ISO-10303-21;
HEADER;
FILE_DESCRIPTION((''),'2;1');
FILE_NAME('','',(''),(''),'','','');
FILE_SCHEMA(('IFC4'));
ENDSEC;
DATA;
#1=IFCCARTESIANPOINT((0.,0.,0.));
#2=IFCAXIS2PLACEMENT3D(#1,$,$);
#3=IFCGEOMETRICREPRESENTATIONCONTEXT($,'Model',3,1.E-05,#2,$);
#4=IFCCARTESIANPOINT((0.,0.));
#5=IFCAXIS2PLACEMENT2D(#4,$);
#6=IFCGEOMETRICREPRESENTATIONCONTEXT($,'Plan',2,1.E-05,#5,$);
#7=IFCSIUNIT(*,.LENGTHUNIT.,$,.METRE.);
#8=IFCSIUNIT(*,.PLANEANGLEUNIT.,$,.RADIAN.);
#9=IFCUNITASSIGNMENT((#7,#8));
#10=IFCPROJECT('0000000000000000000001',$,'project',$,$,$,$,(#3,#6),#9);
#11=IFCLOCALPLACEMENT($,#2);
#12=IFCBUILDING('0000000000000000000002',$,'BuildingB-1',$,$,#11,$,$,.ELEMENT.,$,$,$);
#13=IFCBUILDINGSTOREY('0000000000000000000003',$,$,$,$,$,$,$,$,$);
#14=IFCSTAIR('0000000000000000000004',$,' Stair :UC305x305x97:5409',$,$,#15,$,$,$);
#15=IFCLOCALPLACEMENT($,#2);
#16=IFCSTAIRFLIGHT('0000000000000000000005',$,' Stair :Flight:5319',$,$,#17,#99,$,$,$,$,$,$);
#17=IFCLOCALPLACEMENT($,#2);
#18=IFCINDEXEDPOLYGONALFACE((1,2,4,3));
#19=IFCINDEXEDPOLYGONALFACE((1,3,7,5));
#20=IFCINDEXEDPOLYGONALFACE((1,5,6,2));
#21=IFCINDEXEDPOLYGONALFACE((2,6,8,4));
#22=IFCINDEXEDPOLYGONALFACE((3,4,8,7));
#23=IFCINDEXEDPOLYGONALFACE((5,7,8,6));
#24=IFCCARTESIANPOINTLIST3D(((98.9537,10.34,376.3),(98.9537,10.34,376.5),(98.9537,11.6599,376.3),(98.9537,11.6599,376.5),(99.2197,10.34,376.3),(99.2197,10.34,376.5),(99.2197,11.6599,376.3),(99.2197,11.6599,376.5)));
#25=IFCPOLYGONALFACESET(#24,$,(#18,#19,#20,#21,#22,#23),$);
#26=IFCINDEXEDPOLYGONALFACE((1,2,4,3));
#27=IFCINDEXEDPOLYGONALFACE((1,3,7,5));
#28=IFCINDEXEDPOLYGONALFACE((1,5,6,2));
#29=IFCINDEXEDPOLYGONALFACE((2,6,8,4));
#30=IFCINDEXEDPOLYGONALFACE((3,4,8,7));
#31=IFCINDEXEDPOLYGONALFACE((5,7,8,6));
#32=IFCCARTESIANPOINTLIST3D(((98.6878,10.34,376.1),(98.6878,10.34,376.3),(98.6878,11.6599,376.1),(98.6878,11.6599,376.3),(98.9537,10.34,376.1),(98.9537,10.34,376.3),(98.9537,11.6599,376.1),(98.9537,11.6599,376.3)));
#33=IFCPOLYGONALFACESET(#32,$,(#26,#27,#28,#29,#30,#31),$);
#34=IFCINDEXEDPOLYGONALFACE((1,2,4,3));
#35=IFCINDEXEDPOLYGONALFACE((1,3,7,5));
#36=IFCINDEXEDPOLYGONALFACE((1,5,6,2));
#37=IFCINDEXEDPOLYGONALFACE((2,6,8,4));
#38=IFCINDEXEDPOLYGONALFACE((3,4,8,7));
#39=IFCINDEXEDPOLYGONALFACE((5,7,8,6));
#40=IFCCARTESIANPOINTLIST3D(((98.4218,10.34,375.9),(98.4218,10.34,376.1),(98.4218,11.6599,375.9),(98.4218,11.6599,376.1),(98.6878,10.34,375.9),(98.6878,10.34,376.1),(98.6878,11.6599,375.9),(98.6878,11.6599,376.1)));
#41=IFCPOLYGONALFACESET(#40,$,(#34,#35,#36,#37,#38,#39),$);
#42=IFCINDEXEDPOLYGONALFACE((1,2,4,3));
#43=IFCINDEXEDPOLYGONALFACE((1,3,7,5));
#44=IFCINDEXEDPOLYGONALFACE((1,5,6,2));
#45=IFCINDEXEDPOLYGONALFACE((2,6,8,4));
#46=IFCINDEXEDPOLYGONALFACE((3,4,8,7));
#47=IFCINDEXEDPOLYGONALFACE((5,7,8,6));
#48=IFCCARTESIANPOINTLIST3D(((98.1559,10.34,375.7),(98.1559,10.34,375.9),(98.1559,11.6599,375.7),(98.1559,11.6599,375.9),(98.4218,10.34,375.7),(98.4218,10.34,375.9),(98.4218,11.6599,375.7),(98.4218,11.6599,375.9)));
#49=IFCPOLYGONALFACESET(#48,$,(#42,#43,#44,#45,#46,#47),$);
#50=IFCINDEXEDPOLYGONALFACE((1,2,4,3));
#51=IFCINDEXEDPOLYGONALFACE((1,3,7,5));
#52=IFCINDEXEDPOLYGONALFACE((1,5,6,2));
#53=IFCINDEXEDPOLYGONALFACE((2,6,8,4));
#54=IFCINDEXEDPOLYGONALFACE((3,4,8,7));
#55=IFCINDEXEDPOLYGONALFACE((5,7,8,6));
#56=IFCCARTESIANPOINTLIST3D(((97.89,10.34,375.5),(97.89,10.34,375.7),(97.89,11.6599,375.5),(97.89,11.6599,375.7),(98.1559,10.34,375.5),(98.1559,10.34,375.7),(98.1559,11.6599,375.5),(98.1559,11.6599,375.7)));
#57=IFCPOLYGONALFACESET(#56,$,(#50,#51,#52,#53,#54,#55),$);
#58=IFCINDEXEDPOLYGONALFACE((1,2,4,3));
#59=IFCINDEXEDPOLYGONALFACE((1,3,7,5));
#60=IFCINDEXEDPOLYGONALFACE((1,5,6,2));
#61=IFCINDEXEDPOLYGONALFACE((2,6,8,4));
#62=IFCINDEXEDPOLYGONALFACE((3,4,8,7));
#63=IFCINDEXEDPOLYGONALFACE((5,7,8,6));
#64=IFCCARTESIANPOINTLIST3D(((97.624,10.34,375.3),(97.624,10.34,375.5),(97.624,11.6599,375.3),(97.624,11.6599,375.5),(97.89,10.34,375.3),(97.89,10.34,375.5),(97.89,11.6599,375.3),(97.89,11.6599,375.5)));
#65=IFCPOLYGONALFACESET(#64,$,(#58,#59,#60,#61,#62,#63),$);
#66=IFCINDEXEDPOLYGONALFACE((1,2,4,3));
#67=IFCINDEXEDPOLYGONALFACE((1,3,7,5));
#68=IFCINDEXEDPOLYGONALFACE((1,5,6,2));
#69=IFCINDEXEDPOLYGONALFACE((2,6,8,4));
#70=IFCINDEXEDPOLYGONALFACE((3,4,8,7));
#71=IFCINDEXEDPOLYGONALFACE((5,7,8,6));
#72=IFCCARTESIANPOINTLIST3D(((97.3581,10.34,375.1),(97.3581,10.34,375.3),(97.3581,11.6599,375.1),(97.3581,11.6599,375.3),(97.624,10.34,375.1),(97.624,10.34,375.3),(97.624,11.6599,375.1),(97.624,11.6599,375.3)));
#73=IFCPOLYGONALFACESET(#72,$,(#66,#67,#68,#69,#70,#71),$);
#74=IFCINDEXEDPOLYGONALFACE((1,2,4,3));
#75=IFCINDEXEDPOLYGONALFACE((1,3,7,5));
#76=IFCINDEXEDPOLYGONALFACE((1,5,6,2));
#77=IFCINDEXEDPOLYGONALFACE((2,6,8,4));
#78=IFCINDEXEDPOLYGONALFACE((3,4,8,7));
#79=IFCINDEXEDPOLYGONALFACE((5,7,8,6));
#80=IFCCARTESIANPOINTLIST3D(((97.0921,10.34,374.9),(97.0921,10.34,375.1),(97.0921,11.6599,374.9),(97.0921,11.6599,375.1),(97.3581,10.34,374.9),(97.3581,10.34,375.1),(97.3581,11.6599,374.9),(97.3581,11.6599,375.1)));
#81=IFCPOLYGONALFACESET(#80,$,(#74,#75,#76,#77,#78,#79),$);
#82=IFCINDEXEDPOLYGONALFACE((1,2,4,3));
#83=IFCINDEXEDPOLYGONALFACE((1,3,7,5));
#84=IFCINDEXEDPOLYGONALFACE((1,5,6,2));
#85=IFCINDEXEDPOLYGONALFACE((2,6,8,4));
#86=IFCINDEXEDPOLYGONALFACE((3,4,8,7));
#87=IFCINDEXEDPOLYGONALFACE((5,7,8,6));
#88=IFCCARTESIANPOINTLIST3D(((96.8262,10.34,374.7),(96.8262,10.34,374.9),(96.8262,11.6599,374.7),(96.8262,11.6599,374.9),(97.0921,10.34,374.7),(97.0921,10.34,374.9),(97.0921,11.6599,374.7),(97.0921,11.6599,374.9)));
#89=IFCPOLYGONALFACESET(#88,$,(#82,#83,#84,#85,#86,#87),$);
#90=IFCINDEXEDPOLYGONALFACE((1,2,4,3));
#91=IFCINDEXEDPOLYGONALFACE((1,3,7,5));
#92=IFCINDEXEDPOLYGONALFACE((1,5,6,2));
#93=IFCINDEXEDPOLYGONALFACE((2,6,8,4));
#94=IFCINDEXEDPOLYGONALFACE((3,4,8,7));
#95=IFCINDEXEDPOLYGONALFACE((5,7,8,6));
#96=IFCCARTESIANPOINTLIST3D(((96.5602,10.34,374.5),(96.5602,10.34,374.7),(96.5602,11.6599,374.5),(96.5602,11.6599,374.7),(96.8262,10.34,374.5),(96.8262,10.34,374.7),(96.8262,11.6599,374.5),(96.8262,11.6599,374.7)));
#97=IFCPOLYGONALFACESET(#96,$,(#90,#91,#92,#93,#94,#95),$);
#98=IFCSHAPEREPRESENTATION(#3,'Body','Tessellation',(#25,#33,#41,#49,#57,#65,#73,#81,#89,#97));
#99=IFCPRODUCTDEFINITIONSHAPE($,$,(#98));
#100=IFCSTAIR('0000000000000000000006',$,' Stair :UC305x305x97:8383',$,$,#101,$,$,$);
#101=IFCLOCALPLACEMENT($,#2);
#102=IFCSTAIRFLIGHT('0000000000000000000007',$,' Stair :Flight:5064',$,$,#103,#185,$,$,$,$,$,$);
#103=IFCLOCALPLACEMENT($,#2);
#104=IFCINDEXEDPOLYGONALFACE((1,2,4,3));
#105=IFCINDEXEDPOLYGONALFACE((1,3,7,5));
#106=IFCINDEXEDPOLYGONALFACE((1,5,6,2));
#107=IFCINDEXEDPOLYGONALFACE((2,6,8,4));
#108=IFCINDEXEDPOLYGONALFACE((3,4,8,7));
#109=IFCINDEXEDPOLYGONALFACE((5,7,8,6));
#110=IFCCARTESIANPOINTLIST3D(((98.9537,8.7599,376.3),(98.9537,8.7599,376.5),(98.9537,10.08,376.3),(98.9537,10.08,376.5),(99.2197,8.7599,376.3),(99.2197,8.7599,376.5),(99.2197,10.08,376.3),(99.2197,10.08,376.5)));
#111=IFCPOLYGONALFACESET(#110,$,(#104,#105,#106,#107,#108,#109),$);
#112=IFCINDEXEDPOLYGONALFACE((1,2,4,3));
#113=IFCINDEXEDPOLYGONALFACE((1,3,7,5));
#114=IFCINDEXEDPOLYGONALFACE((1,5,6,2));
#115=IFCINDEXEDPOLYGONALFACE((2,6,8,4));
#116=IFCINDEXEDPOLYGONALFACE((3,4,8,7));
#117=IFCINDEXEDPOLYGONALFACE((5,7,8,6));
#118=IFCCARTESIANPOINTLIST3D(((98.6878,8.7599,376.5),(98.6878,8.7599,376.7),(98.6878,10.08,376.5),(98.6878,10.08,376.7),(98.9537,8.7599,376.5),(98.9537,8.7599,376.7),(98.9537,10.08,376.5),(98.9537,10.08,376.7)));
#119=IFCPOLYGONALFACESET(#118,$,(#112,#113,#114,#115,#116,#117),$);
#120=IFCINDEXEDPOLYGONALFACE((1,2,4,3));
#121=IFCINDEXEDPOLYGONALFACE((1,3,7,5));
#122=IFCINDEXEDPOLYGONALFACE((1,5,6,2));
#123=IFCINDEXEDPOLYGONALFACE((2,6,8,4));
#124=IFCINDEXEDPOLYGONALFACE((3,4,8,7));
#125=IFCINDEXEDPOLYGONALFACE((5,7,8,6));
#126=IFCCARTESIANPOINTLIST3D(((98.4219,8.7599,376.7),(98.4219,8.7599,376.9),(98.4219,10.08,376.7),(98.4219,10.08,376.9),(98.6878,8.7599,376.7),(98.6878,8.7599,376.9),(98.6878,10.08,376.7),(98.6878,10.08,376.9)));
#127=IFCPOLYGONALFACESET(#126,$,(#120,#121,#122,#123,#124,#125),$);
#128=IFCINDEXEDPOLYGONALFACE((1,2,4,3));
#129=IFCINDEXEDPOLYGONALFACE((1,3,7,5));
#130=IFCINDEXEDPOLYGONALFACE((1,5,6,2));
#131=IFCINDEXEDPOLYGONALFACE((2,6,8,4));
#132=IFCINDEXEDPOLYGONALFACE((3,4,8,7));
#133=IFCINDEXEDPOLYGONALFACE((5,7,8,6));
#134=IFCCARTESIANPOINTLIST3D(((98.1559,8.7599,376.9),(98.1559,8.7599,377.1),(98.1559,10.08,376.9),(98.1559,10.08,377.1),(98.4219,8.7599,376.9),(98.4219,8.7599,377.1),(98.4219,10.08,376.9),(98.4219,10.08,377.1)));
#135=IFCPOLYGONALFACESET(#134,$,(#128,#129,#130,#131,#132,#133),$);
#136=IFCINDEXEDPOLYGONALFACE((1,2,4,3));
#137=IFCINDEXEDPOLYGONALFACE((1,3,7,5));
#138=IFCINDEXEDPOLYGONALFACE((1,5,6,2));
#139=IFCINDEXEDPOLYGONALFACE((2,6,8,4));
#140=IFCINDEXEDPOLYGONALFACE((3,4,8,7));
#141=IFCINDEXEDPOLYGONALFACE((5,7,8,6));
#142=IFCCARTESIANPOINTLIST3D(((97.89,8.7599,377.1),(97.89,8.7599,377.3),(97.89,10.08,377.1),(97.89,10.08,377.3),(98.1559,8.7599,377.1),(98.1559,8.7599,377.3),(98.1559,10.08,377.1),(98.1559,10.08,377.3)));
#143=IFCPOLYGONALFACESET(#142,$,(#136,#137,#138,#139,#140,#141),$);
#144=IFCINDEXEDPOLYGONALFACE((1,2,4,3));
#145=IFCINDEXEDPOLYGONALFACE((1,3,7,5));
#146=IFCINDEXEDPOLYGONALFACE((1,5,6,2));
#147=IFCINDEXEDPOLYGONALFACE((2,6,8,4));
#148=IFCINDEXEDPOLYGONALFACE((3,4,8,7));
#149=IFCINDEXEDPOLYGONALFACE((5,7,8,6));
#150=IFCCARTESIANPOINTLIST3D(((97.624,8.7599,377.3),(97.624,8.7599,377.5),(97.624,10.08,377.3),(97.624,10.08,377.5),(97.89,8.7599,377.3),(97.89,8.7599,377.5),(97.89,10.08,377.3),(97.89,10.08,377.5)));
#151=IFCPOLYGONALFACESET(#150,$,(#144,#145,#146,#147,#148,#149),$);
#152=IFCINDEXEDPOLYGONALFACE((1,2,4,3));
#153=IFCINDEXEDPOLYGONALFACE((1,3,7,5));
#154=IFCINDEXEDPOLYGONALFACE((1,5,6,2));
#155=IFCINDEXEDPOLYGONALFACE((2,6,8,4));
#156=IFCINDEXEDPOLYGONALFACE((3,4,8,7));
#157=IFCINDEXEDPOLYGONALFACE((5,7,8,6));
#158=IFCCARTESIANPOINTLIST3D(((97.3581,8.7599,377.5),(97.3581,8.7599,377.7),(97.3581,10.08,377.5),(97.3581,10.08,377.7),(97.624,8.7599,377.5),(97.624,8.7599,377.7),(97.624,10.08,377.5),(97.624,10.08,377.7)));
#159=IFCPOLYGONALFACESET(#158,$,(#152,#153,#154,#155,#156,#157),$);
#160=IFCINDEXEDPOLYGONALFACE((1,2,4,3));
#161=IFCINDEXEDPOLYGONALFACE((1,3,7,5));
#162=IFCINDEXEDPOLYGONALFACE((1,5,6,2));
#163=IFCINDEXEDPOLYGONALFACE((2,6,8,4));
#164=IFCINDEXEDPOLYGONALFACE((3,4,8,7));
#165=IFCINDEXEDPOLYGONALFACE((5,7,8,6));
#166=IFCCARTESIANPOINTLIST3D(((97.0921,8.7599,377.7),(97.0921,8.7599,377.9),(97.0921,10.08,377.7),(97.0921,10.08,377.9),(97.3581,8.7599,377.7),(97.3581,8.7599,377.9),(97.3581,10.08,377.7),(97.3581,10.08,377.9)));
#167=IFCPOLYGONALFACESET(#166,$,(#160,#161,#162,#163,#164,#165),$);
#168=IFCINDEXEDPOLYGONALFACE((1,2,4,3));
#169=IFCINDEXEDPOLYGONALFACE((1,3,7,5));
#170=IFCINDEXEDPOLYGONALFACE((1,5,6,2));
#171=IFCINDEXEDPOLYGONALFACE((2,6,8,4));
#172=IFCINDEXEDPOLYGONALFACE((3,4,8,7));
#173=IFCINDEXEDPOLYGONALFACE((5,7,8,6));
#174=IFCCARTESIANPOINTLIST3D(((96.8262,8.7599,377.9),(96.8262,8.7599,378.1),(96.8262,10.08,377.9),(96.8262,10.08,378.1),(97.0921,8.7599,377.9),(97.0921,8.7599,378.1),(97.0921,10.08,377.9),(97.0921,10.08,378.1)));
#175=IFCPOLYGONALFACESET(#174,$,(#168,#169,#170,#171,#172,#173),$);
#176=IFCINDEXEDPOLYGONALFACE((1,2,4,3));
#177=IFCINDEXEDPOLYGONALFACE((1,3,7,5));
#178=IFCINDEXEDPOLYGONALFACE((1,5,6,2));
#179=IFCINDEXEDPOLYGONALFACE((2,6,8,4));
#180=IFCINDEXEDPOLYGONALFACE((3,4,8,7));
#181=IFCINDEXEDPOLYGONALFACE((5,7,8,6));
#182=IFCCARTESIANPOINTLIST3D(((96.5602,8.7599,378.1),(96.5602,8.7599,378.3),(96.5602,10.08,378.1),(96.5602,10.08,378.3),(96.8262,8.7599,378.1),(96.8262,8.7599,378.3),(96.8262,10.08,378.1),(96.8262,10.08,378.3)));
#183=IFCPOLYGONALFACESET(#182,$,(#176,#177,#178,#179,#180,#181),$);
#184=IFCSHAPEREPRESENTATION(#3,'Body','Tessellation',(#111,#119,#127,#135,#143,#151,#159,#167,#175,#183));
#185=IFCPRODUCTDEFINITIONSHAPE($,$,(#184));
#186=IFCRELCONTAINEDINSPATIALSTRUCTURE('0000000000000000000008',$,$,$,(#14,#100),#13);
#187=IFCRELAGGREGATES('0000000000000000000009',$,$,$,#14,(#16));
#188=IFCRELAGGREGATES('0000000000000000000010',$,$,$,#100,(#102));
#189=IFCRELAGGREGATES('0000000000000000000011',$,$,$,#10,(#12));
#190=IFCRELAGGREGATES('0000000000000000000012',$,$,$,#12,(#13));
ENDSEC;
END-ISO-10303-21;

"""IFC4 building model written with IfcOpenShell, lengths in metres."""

from ifc_helpers import new_model, si_unit, frame, origin, origin_2d, place, context, project, spatial, polyline, outline, extrude, element, aggregate, save


model = new_model("IFC4")

# Units and contexts
model_context = context("Model", 3, precision=1e-05, world=origin())
plan_context = context("Plan", 2, precision=1e-05, world=origin_2d())
ifc_project = project(units=[si_unit("LENGTHUNIT", "METRE"), si_unit("PLANEANGLEUNIT", "RADIAN")], contexts=[model_context, plan_context])

# Building, storey
building_placement = place(None, origin())
building = spatial("IfcBuilding", under=ifc_project, at=building_placement, Name="BuildingB-1", CompositionType="ELEMENT")
storey = spatial("IfcBuildingStorey", under=building)

# Stairs, stair flights
stair_1 = element("IfcStair", 1, inside=storey, Name=" Stair :UC305x305x97:5409")
stair_flight_1 = element("IfcStairFlight", 2, Name=" Stair :Flight:5319", context=model_context, shape_type="SweptSolid", body=[
    extrude(outline(polyline([(98.9537, 11.6599, 376.5), (98.9537, 10.34, 376.5), (99.2197, 10.34, 376.5), (99.2197, 11.6599, 376.5), (98.9537, 11.6599, 376.5)])), origin(), (0.0, 0.0, -1.0), 0.2),
    extrude(outline(polyline([(98.6878, 11.6599, 376.5), (98.6878, 10.34, 376.5), (98.9537, 10.34, 376.5), (98.9537, 11.6599, 376.5), (98.6878, 11.6599, 376.5)])), frame((0.0, 0.0, -0.2)), (0.0, 0.0, -1.0), 0.2),
    extrude(outline(polyline([(98.4218, 11.6599, 376.5), (98.4218, 10.34, 376.5), (98.6878, 10.34, 376.5), (98.6878, 11.6599, 376.5), (98.4218, 11.6599, 376.5)])), frame((0.0, 0.0, -0.4)), (0.0, 0.0, -1.0), 0.2),
    extrude(outline(polyline([(98.1559, 11.6599, 376.5), (98.1559, 10.34, 376.5), (98.4218, 10.34, 376.5), (98.4218, 11.6599, 376.5), (98.1559, 11.6599, 376.5)])), frame((0.0, 0.0, -0.6)), (0.0, 0.0, -1.0), 0.2),
    extrude(outline(polyline([(97.89, 11.6599, 376.5), (97.89, 10.34, 376.5), (98.1559, 10.34, 376.5), (98.1559, 11.6599, 376.5), (97.89, 11.6599, 376.5)])), frame((0.0, 0.0, -0.8)), (0.0, 0.0, -1.0), 0.2),
    extrude(outline(polyline([(97.624, 11.6599, 376.5), (97.624, 10.34, 376.5), (97.89, 10.34, 376.5), (97.89, 11.6599, 376.5), (97.624, 11.6599, 376.5)])), frame((0.0, 0.0, -1.0)), (0.0, 0.0, -1.0), 0.2),
    extrude(outline(polyline([(97.3581, 11.6599, 376.5), (97.3581, 10.34, 376.5), (97.624, 10.34, 376.5), (97.624, 11.6599, 376.5), (97.3581, 11.6599, 376.5)])), frame((0.0, 0.0, -1.2)), (0.0, 0.0, -1.0), 0.2),
    extrude(outline(polyline([(97.0921, 11.6599, 376.5), (97.0921, 10.34, 376.5), (97.3581, 10.34, 376.5), (97.3581, 11.6599, 376.5), (97.0921, 11.6599, 376.5)])), frame((0.0, 0.0, -1.4)), (0.0, 0.0, -1.0), 0.2),
    extrude(outline(polyline([(96.8262, 11.6599, 376.5), (96.8262, 10.34, 376.5), (97.0921, 10.34, 376.5), (97.0921, 11.6599, 376.5), (96.8262, 11.6599, 376.5)])), frame((0.0, 0.0, -1.6)), (0.0, 0.0, -1.0), 0.2),
    extrude(outline(polyline([(96.5602, 11.6599, 376.5), (96.5602, 10.34, 376.5), (96.8262, 10.34, 376.5), (96.8262, 11.6599, 376.5), (96.5602, 11.6599, 376.5)])), frame((0.0, 0.0, -1.8)), (0.0, 0.0, -1.0), 0.2),
])
aggregate(stair_1, [stair_flight_1])
stair_2 = element("IfcStair", 3, inside=storey, Name=" Stair :UC305x305x97:8383")
stair_flight_2 = element("IfcStairFlight", 4, Name=" Stair :Flight:5064", context=model_context, shape_type="SweptSolid", body=[
    extrude(outline(polyline([(98.9537, 8.7599, 376.5), (98.9537, 10.08, 376.5), (99.2197, 10.08, 376.5), (99.2197, 8.7599, 376.5), (98.9537, 8.7599, 376.5)])), origin(), (0.0, 0.0, -1.0), 0.2),
    extrude(outline(polyline([(98.6878, 8.7599, 376.5), (98.6878, 10.08, 376.5), (98.9537, 10.08, 376.5), (98.9537, 8.7599, 376.5), (98.6878, 8.7599, 376.5)])), frame((0.0, 0.0, 0.2)), (0.0, 0.0, -1.0), 0.2),
    extrude(outline(polyline([(98.4219, 8.7599, 376.5), (98.4219, 10.08, 376.5), (98.6878, 10.08, 376.5), (98.6878, 8.7599, 376.5), (98.4219, 8.7599, 376.5)])), frame((0.0, 0.0, 0.4)), (0.0, 0.0, -1.0), 0.2),
    extrude(outline(polyline([(98.1559, 8.7599, 376.5), (98.1559, 10.08, 376.5), (98.4219, 10.08, 376.5), (98.4219, 8.7599, 376.5), (98.1559, 8.7599, 376.5)])), frame((0.0, 0.0, 0.6)), (0.0, 0.0, -1.0), 0.2),
    extrude(outline(polyline([(97.89, 8.7599, 376.5), (97.89, 10.08, 376.5), (98.1559, 10.08, 376.5), (98.1559, 8.7599, 376.5), (97.89, 8.7599, 376.5)])), frame((0.0, 0.0, 0.8)), (0.0, 0.0, -1.0), 0.2),
    extrude(outline(polyline([(97.624, 8.7599, 376.5), (97.624, 10.08, 376.5), (97.89, 10.08, 376.5), (97.89, 8.7599, 376.5), (97.624, 8.7599, 376.5)])), frame((0.0, 0.0, 1.0)), (0.0, 0.0, -1.0), 0.2),
    extrude(outline(polyline([(97.3581, 8.7599, 376.5), (97.3581, 10.08, 376.5), (97.624, 10.08, 376.5), (97.624, 8.7599, 376.5), (97.3581, 8.7599, 376.5)])), frame((0.0, 0.0, 1.2)), (0.0, 0.0, -1.0), 0.2),
    extrude(outline(polyline([(97.0921, 8.7599, 376.5), (97.0921, 10.08, 376.5), (97.3581, 10.08, 376.5), (97.3581, 8.7599, 376.5), (97.0921, 8.7599, 376.5)])), frame((0.0, 0.0, 1.4)), (0.0, 0.0, -1.0), 0.2),
    extrude(outline(polyline([(96.8262, 8.7599, 376.5), (96.8262, 10.08, 376.5), (97.0921, 10.08, 376.5), (97.0921, 8.7599, 376.5), (96.8262, 8.7599, 376.5)])), frame((0.0, 0.0, 1.6)), (0.0, 0.0, -1.0), 0.2),
    extrude(outline(polyline([(96.5602, 8.7599, 376.5), (96.5602, 10.08, 376.5), (96.8262, 10.08, 376.5), (96.8262, 8.7599, 376.5), (96.5602, 8.7599, 376.5)])), frame((0.0, 0.0, 1.8)), (0.0, 0.0, -1.0), 0.2),
])
aggregate(stair_2, [stair_flight_2])

save(model, "model.ifc")
